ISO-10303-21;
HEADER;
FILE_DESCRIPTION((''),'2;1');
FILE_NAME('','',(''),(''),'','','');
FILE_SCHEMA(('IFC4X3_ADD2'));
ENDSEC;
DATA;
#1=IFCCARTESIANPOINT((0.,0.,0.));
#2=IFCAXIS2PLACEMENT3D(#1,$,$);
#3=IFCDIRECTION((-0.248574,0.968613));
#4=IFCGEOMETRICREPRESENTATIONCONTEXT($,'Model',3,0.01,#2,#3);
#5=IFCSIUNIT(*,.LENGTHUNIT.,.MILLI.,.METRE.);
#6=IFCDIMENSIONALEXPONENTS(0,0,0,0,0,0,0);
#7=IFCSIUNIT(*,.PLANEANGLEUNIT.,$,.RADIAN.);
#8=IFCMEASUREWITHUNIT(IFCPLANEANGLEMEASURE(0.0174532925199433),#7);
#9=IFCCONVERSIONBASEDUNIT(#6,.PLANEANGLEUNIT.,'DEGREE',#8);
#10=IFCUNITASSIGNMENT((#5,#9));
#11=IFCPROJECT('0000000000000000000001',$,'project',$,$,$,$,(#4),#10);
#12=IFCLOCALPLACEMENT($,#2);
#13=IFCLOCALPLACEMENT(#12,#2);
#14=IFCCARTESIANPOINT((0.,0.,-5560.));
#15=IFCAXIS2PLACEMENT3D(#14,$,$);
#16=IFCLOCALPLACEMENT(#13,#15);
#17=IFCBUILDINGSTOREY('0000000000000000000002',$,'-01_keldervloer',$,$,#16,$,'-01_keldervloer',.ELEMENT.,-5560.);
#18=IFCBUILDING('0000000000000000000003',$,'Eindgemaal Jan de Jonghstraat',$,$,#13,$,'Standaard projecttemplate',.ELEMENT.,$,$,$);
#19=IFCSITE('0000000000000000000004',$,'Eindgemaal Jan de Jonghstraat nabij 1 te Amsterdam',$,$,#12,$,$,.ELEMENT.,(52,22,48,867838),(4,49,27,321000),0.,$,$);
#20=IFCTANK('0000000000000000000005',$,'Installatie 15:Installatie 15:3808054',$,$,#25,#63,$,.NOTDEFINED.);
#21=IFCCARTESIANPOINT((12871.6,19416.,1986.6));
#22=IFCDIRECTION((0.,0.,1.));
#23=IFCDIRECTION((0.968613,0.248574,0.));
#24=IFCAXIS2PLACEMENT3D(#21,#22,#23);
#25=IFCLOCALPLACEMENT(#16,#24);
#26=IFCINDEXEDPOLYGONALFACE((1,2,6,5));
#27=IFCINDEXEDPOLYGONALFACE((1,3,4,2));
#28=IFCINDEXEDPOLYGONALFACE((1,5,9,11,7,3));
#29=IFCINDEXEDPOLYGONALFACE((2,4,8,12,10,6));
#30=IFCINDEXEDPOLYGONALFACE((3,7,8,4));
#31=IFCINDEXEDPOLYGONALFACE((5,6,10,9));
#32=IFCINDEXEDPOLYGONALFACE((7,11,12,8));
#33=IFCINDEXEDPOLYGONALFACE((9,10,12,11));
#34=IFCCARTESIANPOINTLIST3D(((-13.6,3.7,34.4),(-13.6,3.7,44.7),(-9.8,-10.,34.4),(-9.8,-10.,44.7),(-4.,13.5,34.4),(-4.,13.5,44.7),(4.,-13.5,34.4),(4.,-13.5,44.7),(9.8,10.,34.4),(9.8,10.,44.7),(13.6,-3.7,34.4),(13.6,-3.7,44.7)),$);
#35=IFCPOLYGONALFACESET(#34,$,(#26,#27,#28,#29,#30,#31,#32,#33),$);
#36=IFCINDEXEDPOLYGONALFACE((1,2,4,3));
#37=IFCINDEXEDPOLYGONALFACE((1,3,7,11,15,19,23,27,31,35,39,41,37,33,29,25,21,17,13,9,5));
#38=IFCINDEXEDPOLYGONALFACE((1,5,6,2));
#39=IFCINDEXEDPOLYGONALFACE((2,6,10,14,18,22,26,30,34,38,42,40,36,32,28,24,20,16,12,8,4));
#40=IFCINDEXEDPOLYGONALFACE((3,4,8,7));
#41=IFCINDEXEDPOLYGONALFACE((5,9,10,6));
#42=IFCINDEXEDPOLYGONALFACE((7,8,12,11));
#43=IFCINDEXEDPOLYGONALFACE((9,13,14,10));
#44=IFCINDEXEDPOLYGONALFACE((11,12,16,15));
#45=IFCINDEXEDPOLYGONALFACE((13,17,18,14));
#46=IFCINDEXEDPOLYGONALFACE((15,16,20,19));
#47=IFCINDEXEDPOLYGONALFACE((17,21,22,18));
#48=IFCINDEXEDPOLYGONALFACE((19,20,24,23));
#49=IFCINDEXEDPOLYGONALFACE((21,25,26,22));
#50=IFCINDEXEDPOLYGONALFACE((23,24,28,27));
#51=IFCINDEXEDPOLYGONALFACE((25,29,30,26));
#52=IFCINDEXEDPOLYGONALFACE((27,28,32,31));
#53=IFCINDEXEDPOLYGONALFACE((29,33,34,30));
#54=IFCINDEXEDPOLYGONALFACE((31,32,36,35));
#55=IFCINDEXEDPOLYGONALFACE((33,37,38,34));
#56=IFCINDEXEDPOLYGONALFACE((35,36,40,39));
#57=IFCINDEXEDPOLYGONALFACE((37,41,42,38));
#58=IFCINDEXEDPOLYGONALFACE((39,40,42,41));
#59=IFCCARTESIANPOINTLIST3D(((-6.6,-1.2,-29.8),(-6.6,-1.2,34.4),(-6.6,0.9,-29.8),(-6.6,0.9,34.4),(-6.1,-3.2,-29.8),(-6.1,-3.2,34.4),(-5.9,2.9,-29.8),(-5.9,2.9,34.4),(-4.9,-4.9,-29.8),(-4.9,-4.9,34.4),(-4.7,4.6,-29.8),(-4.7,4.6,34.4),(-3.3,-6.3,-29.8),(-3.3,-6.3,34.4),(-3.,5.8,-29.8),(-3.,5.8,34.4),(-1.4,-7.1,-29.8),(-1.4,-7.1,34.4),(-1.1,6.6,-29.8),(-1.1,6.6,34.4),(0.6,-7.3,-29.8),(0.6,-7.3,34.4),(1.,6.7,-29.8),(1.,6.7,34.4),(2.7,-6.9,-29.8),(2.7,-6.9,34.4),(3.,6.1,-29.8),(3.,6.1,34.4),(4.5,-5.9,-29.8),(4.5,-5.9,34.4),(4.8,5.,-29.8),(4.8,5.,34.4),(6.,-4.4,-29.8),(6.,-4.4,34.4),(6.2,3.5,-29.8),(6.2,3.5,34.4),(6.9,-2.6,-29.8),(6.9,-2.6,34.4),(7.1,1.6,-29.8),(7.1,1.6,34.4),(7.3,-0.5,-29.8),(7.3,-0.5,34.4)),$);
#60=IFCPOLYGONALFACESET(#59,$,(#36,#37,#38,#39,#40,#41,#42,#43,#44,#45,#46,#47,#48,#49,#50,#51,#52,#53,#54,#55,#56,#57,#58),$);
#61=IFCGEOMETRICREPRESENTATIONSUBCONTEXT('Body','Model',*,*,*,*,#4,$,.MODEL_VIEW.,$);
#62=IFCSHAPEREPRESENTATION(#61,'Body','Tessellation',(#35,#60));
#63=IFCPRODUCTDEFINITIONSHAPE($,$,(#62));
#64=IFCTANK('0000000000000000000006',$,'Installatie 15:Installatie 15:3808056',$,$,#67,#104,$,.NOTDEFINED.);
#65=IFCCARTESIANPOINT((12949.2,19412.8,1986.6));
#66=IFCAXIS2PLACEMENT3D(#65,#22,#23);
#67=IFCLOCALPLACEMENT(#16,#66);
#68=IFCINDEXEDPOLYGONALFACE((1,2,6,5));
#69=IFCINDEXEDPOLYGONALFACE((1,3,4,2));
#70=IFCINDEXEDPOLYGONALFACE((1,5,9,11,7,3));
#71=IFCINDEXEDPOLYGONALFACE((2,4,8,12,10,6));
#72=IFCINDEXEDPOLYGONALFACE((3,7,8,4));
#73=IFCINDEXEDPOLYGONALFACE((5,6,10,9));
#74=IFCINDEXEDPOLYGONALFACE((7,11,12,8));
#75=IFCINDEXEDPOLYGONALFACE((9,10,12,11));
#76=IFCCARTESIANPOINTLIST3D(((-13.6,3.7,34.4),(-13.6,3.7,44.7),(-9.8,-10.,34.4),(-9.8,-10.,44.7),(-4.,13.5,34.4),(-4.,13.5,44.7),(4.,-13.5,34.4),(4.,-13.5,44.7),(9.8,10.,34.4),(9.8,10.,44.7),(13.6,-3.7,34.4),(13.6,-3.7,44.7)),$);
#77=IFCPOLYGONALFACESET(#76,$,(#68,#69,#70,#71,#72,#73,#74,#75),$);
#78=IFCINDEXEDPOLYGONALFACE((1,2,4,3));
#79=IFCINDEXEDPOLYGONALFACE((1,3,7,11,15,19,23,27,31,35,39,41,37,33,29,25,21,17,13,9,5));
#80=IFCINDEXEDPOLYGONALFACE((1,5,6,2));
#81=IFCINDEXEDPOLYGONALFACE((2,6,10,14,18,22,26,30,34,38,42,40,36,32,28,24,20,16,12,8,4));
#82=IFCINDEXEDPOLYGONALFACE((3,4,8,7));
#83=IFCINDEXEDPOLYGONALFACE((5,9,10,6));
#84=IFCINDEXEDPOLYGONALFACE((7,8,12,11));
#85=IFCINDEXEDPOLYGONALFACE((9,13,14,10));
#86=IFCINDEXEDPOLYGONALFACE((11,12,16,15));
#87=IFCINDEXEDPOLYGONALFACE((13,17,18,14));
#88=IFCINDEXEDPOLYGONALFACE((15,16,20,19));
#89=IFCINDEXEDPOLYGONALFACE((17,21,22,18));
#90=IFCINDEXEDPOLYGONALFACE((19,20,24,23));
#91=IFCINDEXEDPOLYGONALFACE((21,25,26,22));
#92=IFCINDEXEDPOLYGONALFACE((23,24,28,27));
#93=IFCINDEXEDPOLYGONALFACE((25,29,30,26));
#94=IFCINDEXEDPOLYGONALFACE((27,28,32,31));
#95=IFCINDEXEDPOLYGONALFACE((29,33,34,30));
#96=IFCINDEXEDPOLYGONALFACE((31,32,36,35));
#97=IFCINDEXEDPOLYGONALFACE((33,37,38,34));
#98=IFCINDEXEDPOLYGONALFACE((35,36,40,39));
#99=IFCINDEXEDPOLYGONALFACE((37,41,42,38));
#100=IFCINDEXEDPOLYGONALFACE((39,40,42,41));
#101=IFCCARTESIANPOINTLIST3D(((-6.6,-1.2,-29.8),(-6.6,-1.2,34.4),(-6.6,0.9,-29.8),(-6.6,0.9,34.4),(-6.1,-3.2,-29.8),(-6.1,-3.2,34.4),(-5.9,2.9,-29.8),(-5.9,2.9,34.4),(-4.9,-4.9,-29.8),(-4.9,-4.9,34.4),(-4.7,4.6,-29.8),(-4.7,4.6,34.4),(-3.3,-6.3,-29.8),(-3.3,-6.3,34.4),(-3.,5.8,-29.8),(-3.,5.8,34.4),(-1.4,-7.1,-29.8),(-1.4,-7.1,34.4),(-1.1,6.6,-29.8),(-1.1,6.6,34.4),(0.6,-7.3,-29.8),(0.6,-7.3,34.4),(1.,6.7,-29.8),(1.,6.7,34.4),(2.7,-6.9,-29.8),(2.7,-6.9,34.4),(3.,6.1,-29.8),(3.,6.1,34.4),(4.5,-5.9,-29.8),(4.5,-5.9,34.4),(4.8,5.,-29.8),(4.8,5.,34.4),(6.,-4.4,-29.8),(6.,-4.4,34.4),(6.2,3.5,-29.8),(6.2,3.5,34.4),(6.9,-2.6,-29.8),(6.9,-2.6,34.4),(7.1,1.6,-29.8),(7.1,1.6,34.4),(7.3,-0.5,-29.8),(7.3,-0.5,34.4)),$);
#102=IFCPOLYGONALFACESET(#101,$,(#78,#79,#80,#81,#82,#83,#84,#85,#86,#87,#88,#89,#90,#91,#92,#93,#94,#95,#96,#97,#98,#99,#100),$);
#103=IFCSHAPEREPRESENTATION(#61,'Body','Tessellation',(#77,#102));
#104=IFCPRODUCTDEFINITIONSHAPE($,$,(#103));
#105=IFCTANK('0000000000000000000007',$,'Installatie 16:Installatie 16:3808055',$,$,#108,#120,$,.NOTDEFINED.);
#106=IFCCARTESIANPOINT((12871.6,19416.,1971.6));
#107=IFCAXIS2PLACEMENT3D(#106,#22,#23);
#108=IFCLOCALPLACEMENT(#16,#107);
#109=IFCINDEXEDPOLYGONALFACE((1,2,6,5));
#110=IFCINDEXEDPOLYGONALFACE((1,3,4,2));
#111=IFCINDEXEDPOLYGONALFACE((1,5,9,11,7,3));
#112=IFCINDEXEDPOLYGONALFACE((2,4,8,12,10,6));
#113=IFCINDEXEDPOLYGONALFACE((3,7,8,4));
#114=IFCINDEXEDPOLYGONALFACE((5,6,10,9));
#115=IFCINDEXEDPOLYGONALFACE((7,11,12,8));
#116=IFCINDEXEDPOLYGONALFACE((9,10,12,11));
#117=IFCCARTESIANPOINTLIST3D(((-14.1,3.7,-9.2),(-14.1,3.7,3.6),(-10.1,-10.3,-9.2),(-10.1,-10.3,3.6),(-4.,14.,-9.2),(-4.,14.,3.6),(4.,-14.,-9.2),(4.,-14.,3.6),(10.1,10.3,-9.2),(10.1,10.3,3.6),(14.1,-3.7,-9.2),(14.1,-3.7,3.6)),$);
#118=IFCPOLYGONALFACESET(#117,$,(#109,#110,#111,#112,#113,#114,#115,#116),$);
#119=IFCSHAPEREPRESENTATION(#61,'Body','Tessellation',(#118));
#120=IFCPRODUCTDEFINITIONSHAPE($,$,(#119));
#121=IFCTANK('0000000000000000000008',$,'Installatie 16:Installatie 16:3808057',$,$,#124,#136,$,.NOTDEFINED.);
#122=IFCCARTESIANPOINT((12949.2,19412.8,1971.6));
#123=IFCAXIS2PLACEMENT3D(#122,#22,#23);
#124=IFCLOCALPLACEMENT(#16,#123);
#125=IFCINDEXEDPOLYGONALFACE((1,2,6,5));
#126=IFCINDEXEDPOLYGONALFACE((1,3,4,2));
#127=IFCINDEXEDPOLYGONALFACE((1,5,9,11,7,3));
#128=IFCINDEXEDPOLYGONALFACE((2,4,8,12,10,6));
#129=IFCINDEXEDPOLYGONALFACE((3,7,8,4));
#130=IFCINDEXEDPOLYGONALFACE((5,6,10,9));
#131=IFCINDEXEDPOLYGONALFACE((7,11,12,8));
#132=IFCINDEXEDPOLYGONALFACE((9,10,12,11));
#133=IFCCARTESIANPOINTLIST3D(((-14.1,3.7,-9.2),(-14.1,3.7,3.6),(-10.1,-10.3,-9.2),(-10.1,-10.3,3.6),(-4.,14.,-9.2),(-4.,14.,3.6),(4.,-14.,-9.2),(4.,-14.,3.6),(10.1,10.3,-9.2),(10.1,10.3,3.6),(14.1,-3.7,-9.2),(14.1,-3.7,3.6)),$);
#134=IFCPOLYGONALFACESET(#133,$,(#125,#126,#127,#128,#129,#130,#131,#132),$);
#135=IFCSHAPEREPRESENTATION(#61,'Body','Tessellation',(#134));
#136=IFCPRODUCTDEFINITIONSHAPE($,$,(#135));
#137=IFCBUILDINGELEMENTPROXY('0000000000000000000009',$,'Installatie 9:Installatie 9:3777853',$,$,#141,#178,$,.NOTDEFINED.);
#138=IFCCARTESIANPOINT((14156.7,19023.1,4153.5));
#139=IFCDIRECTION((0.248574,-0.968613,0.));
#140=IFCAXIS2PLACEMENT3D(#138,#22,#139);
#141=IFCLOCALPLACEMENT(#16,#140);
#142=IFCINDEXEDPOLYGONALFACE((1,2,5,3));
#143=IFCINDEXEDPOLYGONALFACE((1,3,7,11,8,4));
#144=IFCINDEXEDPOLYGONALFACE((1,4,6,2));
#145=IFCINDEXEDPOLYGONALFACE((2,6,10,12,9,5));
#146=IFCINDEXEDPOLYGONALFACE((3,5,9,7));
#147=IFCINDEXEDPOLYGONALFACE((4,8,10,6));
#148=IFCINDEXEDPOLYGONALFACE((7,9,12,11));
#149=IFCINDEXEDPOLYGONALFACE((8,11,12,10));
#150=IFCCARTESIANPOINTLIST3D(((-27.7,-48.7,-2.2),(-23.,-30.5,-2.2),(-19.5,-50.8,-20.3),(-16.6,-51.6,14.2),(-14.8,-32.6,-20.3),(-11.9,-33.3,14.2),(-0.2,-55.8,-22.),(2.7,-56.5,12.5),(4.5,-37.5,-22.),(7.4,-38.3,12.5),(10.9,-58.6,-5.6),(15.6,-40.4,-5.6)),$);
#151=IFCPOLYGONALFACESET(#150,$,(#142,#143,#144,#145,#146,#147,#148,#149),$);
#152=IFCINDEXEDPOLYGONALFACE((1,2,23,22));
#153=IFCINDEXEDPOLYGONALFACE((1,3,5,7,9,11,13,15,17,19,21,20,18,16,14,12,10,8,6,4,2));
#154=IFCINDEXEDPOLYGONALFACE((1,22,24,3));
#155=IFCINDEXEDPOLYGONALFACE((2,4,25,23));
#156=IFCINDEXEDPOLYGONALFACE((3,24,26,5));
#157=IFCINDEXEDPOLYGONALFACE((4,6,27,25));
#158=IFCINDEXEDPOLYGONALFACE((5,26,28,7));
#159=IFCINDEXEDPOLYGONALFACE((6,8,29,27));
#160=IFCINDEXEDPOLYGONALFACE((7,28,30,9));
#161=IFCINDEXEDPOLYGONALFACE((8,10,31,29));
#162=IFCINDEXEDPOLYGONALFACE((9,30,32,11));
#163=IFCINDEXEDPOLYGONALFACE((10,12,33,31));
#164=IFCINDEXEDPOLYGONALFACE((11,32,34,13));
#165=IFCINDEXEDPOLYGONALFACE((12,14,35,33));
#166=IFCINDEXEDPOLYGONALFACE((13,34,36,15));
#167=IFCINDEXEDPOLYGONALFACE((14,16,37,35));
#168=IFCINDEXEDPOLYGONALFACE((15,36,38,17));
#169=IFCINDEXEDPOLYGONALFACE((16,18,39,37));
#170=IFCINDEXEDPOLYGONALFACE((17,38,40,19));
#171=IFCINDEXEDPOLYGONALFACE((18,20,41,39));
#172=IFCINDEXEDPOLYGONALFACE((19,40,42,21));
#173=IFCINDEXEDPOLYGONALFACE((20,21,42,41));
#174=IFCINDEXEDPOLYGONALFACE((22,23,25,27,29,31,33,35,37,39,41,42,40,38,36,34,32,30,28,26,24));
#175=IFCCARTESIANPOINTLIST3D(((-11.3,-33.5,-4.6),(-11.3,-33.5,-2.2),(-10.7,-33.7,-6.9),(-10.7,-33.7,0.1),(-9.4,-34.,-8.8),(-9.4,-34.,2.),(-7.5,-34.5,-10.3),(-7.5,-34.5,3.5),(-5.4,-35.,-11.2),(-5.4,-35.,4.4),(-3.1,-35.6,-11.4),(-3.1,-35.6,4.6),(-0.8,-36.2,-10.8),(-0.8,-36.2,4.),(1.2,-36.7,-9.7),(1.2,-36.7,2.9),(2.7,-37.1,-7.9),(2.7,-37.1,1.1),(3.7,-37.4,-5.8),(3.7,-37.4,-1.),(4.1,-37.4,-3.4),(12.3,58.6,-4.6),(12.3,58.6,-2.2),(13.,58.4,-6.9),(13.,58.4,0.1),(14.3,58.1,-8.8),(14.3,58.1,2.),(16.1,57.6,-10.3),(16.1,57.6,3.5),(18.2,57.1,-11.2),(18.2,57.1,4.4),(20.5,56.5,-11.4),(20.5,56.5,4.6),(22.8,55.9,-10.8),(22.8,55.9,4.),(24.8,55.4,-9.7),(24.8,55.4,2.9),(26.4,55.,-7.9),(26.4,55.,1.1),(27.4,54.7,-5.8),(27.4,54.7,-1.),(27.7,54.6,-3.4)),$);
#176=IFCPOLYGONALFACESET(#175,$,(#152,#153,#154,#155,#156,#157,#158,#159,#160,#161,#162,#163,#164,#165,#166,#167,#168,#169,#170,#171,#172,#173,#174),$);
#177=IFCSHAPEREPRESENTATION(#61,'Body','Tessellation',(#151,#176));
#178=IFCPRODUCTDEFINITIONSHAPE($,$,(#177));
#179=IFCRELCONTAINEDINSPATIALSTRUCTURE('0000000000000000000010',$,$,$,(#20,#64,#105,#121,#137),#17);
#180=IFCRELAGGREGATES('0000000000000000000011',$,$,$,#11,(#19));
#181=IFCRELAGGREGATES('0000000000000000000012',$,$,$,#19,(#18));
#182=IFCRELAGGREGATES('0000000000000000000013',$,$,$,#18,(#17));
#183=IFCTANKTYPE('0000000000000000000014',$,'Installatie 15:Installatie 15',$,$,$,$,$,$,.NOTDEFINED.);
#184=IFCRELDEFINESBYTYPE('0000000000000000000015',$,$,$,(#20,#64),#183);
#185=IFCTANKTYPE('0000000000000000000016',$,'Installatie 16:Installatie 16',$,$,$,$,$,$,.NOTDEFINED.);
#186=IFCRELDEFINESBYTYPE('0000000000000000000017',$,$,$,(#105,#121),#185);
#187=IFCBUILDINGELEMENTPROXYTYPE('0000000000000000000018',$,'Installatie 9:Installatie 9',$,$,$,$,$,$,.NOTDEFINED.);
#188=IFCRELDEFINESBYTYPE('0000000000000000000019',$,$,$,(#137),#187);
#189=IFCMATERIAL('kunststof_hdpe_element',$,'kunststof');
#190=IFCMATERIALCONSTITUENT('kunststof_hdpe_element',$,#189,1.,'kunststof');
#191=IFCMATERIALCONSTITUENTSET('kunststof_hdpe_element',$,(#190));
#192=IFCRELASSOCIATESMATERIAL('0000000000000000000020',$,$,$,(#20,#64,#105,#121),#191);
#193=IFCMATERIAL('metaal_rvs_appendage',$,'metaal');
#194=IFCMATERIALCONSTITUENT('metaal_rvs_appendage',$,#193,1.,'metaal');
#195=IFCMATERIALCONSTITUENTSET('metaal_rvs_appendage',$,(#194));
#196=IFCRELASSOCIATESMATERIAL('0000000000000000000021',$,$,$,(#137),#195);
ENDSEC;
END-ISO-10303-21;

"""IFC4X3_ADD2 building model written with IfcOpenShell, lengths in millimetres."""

from ifc_helpers import new_model, entity, si_unit, converted_unit, direction, frame, frame_2d, origin, place, context, subcontext, project, spatial, polyline, circle, outline, extrude, source, transform, mapped, material, constituent, constituent_set, type_object, type_shapes, element, save


model = new_model("IFC4X3_ADD2")

# Units and contexts
model_context = context("Model", 3, precision=0.01, world=origin(), true_north=direction((-0.248574, 0.968613)))
body_context = subcontext(model_context, "Body", "Model", "MODEL_VIEW")
ifc_project = project(units=[si_unit("LENGTHUNIT", "METRE", prefix="MILLI"), converted_unit("PLANEANGLEUNIT", "DEGREE", entity("IfcPlaneAngleMeasure", 0.0174532925199433), si_unit("PLANEANGLEUNIT", "RADIAN"), dimensions=[0, 0, 0, 0, 0, 0, 0])], contexts=[model_context])

# Site, building, storey
site_placement = place(None, origin())
site = spatial("IfcSite", under=ifc_project, at=site_placement, Name="Eindgemaal Jan de Jonghstraat nabij 1 te Amsterdam", CompositionType="ELEMENT", RefLatitude=(52, 22, 48, 867838), RefLongitude=(4, 49, 27, 321000), RefElevation=0.0)
building_placement = place(site_placement, origin())
building = spatial("IfcBuilding", under=site, at=building_placement, Name="Eindgemaal Jan de Jonghstraat", LongName="Standaard projecttemplate", CompositionType="ELEMENT")
storey_placement = place(building_placement, frame((0.0, 0.0, -5560.0)))
storey = spatial("IfcBuildingStorey", under=building, at=storey_placement, Name="-01_keldervloer", LongName="-01_keldervloer", CompositionType="ELEMENT", Elevation=-5560.0)

# Tanks
ifc_material_1 = material(Name="kunststof_hdpe_element", Category="kunststof")
ifc_constituent_1 = constituent(ifc_material_1, Name="kunststof_hdpe_element", Category="kunststof", fraction=1.0)
ifc_constituent_set_1 = constituent_set(constituents=[ifc_constituent_1], Name="kunststof_hdpe_element")
tank_type_1 = type_object("IfcTankType", Name="Installatie 15:Installatie 15", PredefinedType="NOTDEFINED")
shared_shape_1 = source(origin(), body_context, "Body", "SweptSolid", [
    extrude(outline(polyline([(-7.0, -12.1), (7.3, -12.1), (14.1, -0.2), (7.0, 12.1), (-7.3, 12.1), (-14.1, 0.2), (-7.0, -12.1)])), frame((0.0, 0.0, 34.4), z_axis=(0.0, 0.0, 1.0), x_axis=(-0.968613, 0.248574, 0.0)), (0.0, 0.0, 1.0), 10.3),
    extrude(circle(Radius=7.0, at=frame_2d((0.0, 0.0), x_axis=(1.0, 0.0))), frame((0.3, -0.3, -29.8), z_axis=(0.0, 0.0, 1.0), x_axis=(-0.248574, -0.968613, 0.0)), (0.0, 0.0, 1.0), 64.2),
])
type_shapes(tank_type_1, [shared_shape_1])
for number, where, z_axis, x_axis, name in (
    (1, (12871.6, 19416.0, 1986.6), (0.0, 0.0, 1.0), (0.968613, 0.248574, 0.0), "Installatie 15:Installatie 15:3808054"),
    (2, (12949.2, 19412.8, 1986.6), (0.0, 0.0, 1.0), (0.968613, 0.248574, 0.0), "Installatie 15:Installatie 15:3808056"),
):
    element("IfcTank", number, at=place(storey_placement, frame(where, z_axis=z_axis, x_axis=x_axis)), inside=storey, type_object=tank_type_1, material=ifc_constituent_set_1, Name=name, PredefinedType="NOTDEFINED", context=body_context, shape_type="MappedRepresentation", body=[
        mapped(shared_shape_1, transform((0.0, 0.0, 0.0), scale=1.0)),
    ])
tank_type_2 = type_object("IfcTankType", Name="Installatie 16:Installatie 16", PredefinedType="NOTDEFINED")
shared_shape_2 = source(origin(), body_context, "Body", "SweptSolid", [
    extrude(outline(polyline([(-7.2, -12.5), (7.4, -12.5), (14.6, -0.1), (7.2, 12.5), (-7.4, 12.5), (-14.6, 0.1), (-7.2, -12.5)])), frame((0.0, 0.0, -9.2), z_axis=(0.0, 0.0, 1.0), x_axis=(-0.968613, 0.248574, 0.0)), (0.0, 0.0, 1.0), 12.8),
])
type_shapes(tank_type_2, [shared_shape_2])
for number, where, z_axis, x_axis, name in (
    (3, (12871.6, 19416.0, 1971.6), (0.0, 0.0, 1.0), (0.968613, 0.248574, 0.0), "Installatie 16:Installatie 16:3808055"),
    (4, (12949.2, 19412.8, 1971.6), (0.0, 0.0, 1.0), (0.968613, 0.248574, 0.0), "Installatie 16:Installatie 16:3808057"),
):
    element("IfcTank", number, at=place(storey_placement, frame(where, z_axis=z_axis, x_axis=x_axis)), inside=storey, type_object=tank_type_2, material=ifc_constituent_set_1, Name=name, PredefinedType="NOTDEFINED", context=body_context, shape_type="MappedRepresentation", body=[
        mapped(shared_shape_2, transform((0.0, 0.0, 0.0), scale=1.0)),
    ])

# Building element proxy
ifc_material_2 = material(Name="metaal_rvs_appendage", Category="metaal")
ifc_constituent_2 = constituent(ifc_material_2, Name="metaal_rvs_appendage", Category="metaal", fraction=1.0)
ifc_constituent_set_2 = constituent_set(constituents=[ifc_constituent_2], Name="metaal_rvs_appendage")
building_element_proxy_type = type_object("IfcBuildingElementProxyType", Name="Installatie 9:Installatie 9", PredefinedType="NOTDEFINED")
shared_shape_3 = source(origin(), body_context, "Body", "SweptSolid", [
    extrude(outline(polyline([(-10.0, -17.3), (10.0, -17.3), (20.0, 0.0), (10.0, 17.3), (-10.0, 17.3), (-20.0, 0.0), (-10.0, -17.3)])), frame((-8.4, -53.7, -3.9), z_axis=(0.248574, 0.968613, 0.0), x_axis=(-0.555573, 0.142576, -0.819152)), (0.0, 0.0, 1.0), 18.8),
    extrude(circle(Radius=8.0, at=frame_2d((0.0, 0.0), x_axis=(1.0, 0.0))), frame((-3.7, -35.5, -3.4), z_axis=(0.248574, 0.968613, 0.0), x_axis=(0.968613, -0.248574, 0.0)), (0.0, 0.0, 1.0), 95.1),
])
type_shapes(building_element_proxy_type, [shared_shape_3])
for number, where, z_axis, x_axis, name in (
    (5, (14156.7, 19023.1, 4153.5), (0.0, 0.0, 1.0), (0.248574, -0.968613, 0.0), "Installatie 9:Installatie 9:3777853"),
):
    element("IfcBuildingElementProxy", number, at=place(storey_placement, frame(where, z_axis=z_axis, x_axis=x_axis)), inside=storey, type_object=building_element_proxy_type, material=ifc_constituent_set_2, Name=name, PredefinedType="NOTDEFINED", context=body_context, shape_type="MappedRepresentation", body=[
        mapped(shared_shape_3, transform((0.0, 0.0, 0.0), scale=1.0)),
    ])

save(model, "model.ifc")
